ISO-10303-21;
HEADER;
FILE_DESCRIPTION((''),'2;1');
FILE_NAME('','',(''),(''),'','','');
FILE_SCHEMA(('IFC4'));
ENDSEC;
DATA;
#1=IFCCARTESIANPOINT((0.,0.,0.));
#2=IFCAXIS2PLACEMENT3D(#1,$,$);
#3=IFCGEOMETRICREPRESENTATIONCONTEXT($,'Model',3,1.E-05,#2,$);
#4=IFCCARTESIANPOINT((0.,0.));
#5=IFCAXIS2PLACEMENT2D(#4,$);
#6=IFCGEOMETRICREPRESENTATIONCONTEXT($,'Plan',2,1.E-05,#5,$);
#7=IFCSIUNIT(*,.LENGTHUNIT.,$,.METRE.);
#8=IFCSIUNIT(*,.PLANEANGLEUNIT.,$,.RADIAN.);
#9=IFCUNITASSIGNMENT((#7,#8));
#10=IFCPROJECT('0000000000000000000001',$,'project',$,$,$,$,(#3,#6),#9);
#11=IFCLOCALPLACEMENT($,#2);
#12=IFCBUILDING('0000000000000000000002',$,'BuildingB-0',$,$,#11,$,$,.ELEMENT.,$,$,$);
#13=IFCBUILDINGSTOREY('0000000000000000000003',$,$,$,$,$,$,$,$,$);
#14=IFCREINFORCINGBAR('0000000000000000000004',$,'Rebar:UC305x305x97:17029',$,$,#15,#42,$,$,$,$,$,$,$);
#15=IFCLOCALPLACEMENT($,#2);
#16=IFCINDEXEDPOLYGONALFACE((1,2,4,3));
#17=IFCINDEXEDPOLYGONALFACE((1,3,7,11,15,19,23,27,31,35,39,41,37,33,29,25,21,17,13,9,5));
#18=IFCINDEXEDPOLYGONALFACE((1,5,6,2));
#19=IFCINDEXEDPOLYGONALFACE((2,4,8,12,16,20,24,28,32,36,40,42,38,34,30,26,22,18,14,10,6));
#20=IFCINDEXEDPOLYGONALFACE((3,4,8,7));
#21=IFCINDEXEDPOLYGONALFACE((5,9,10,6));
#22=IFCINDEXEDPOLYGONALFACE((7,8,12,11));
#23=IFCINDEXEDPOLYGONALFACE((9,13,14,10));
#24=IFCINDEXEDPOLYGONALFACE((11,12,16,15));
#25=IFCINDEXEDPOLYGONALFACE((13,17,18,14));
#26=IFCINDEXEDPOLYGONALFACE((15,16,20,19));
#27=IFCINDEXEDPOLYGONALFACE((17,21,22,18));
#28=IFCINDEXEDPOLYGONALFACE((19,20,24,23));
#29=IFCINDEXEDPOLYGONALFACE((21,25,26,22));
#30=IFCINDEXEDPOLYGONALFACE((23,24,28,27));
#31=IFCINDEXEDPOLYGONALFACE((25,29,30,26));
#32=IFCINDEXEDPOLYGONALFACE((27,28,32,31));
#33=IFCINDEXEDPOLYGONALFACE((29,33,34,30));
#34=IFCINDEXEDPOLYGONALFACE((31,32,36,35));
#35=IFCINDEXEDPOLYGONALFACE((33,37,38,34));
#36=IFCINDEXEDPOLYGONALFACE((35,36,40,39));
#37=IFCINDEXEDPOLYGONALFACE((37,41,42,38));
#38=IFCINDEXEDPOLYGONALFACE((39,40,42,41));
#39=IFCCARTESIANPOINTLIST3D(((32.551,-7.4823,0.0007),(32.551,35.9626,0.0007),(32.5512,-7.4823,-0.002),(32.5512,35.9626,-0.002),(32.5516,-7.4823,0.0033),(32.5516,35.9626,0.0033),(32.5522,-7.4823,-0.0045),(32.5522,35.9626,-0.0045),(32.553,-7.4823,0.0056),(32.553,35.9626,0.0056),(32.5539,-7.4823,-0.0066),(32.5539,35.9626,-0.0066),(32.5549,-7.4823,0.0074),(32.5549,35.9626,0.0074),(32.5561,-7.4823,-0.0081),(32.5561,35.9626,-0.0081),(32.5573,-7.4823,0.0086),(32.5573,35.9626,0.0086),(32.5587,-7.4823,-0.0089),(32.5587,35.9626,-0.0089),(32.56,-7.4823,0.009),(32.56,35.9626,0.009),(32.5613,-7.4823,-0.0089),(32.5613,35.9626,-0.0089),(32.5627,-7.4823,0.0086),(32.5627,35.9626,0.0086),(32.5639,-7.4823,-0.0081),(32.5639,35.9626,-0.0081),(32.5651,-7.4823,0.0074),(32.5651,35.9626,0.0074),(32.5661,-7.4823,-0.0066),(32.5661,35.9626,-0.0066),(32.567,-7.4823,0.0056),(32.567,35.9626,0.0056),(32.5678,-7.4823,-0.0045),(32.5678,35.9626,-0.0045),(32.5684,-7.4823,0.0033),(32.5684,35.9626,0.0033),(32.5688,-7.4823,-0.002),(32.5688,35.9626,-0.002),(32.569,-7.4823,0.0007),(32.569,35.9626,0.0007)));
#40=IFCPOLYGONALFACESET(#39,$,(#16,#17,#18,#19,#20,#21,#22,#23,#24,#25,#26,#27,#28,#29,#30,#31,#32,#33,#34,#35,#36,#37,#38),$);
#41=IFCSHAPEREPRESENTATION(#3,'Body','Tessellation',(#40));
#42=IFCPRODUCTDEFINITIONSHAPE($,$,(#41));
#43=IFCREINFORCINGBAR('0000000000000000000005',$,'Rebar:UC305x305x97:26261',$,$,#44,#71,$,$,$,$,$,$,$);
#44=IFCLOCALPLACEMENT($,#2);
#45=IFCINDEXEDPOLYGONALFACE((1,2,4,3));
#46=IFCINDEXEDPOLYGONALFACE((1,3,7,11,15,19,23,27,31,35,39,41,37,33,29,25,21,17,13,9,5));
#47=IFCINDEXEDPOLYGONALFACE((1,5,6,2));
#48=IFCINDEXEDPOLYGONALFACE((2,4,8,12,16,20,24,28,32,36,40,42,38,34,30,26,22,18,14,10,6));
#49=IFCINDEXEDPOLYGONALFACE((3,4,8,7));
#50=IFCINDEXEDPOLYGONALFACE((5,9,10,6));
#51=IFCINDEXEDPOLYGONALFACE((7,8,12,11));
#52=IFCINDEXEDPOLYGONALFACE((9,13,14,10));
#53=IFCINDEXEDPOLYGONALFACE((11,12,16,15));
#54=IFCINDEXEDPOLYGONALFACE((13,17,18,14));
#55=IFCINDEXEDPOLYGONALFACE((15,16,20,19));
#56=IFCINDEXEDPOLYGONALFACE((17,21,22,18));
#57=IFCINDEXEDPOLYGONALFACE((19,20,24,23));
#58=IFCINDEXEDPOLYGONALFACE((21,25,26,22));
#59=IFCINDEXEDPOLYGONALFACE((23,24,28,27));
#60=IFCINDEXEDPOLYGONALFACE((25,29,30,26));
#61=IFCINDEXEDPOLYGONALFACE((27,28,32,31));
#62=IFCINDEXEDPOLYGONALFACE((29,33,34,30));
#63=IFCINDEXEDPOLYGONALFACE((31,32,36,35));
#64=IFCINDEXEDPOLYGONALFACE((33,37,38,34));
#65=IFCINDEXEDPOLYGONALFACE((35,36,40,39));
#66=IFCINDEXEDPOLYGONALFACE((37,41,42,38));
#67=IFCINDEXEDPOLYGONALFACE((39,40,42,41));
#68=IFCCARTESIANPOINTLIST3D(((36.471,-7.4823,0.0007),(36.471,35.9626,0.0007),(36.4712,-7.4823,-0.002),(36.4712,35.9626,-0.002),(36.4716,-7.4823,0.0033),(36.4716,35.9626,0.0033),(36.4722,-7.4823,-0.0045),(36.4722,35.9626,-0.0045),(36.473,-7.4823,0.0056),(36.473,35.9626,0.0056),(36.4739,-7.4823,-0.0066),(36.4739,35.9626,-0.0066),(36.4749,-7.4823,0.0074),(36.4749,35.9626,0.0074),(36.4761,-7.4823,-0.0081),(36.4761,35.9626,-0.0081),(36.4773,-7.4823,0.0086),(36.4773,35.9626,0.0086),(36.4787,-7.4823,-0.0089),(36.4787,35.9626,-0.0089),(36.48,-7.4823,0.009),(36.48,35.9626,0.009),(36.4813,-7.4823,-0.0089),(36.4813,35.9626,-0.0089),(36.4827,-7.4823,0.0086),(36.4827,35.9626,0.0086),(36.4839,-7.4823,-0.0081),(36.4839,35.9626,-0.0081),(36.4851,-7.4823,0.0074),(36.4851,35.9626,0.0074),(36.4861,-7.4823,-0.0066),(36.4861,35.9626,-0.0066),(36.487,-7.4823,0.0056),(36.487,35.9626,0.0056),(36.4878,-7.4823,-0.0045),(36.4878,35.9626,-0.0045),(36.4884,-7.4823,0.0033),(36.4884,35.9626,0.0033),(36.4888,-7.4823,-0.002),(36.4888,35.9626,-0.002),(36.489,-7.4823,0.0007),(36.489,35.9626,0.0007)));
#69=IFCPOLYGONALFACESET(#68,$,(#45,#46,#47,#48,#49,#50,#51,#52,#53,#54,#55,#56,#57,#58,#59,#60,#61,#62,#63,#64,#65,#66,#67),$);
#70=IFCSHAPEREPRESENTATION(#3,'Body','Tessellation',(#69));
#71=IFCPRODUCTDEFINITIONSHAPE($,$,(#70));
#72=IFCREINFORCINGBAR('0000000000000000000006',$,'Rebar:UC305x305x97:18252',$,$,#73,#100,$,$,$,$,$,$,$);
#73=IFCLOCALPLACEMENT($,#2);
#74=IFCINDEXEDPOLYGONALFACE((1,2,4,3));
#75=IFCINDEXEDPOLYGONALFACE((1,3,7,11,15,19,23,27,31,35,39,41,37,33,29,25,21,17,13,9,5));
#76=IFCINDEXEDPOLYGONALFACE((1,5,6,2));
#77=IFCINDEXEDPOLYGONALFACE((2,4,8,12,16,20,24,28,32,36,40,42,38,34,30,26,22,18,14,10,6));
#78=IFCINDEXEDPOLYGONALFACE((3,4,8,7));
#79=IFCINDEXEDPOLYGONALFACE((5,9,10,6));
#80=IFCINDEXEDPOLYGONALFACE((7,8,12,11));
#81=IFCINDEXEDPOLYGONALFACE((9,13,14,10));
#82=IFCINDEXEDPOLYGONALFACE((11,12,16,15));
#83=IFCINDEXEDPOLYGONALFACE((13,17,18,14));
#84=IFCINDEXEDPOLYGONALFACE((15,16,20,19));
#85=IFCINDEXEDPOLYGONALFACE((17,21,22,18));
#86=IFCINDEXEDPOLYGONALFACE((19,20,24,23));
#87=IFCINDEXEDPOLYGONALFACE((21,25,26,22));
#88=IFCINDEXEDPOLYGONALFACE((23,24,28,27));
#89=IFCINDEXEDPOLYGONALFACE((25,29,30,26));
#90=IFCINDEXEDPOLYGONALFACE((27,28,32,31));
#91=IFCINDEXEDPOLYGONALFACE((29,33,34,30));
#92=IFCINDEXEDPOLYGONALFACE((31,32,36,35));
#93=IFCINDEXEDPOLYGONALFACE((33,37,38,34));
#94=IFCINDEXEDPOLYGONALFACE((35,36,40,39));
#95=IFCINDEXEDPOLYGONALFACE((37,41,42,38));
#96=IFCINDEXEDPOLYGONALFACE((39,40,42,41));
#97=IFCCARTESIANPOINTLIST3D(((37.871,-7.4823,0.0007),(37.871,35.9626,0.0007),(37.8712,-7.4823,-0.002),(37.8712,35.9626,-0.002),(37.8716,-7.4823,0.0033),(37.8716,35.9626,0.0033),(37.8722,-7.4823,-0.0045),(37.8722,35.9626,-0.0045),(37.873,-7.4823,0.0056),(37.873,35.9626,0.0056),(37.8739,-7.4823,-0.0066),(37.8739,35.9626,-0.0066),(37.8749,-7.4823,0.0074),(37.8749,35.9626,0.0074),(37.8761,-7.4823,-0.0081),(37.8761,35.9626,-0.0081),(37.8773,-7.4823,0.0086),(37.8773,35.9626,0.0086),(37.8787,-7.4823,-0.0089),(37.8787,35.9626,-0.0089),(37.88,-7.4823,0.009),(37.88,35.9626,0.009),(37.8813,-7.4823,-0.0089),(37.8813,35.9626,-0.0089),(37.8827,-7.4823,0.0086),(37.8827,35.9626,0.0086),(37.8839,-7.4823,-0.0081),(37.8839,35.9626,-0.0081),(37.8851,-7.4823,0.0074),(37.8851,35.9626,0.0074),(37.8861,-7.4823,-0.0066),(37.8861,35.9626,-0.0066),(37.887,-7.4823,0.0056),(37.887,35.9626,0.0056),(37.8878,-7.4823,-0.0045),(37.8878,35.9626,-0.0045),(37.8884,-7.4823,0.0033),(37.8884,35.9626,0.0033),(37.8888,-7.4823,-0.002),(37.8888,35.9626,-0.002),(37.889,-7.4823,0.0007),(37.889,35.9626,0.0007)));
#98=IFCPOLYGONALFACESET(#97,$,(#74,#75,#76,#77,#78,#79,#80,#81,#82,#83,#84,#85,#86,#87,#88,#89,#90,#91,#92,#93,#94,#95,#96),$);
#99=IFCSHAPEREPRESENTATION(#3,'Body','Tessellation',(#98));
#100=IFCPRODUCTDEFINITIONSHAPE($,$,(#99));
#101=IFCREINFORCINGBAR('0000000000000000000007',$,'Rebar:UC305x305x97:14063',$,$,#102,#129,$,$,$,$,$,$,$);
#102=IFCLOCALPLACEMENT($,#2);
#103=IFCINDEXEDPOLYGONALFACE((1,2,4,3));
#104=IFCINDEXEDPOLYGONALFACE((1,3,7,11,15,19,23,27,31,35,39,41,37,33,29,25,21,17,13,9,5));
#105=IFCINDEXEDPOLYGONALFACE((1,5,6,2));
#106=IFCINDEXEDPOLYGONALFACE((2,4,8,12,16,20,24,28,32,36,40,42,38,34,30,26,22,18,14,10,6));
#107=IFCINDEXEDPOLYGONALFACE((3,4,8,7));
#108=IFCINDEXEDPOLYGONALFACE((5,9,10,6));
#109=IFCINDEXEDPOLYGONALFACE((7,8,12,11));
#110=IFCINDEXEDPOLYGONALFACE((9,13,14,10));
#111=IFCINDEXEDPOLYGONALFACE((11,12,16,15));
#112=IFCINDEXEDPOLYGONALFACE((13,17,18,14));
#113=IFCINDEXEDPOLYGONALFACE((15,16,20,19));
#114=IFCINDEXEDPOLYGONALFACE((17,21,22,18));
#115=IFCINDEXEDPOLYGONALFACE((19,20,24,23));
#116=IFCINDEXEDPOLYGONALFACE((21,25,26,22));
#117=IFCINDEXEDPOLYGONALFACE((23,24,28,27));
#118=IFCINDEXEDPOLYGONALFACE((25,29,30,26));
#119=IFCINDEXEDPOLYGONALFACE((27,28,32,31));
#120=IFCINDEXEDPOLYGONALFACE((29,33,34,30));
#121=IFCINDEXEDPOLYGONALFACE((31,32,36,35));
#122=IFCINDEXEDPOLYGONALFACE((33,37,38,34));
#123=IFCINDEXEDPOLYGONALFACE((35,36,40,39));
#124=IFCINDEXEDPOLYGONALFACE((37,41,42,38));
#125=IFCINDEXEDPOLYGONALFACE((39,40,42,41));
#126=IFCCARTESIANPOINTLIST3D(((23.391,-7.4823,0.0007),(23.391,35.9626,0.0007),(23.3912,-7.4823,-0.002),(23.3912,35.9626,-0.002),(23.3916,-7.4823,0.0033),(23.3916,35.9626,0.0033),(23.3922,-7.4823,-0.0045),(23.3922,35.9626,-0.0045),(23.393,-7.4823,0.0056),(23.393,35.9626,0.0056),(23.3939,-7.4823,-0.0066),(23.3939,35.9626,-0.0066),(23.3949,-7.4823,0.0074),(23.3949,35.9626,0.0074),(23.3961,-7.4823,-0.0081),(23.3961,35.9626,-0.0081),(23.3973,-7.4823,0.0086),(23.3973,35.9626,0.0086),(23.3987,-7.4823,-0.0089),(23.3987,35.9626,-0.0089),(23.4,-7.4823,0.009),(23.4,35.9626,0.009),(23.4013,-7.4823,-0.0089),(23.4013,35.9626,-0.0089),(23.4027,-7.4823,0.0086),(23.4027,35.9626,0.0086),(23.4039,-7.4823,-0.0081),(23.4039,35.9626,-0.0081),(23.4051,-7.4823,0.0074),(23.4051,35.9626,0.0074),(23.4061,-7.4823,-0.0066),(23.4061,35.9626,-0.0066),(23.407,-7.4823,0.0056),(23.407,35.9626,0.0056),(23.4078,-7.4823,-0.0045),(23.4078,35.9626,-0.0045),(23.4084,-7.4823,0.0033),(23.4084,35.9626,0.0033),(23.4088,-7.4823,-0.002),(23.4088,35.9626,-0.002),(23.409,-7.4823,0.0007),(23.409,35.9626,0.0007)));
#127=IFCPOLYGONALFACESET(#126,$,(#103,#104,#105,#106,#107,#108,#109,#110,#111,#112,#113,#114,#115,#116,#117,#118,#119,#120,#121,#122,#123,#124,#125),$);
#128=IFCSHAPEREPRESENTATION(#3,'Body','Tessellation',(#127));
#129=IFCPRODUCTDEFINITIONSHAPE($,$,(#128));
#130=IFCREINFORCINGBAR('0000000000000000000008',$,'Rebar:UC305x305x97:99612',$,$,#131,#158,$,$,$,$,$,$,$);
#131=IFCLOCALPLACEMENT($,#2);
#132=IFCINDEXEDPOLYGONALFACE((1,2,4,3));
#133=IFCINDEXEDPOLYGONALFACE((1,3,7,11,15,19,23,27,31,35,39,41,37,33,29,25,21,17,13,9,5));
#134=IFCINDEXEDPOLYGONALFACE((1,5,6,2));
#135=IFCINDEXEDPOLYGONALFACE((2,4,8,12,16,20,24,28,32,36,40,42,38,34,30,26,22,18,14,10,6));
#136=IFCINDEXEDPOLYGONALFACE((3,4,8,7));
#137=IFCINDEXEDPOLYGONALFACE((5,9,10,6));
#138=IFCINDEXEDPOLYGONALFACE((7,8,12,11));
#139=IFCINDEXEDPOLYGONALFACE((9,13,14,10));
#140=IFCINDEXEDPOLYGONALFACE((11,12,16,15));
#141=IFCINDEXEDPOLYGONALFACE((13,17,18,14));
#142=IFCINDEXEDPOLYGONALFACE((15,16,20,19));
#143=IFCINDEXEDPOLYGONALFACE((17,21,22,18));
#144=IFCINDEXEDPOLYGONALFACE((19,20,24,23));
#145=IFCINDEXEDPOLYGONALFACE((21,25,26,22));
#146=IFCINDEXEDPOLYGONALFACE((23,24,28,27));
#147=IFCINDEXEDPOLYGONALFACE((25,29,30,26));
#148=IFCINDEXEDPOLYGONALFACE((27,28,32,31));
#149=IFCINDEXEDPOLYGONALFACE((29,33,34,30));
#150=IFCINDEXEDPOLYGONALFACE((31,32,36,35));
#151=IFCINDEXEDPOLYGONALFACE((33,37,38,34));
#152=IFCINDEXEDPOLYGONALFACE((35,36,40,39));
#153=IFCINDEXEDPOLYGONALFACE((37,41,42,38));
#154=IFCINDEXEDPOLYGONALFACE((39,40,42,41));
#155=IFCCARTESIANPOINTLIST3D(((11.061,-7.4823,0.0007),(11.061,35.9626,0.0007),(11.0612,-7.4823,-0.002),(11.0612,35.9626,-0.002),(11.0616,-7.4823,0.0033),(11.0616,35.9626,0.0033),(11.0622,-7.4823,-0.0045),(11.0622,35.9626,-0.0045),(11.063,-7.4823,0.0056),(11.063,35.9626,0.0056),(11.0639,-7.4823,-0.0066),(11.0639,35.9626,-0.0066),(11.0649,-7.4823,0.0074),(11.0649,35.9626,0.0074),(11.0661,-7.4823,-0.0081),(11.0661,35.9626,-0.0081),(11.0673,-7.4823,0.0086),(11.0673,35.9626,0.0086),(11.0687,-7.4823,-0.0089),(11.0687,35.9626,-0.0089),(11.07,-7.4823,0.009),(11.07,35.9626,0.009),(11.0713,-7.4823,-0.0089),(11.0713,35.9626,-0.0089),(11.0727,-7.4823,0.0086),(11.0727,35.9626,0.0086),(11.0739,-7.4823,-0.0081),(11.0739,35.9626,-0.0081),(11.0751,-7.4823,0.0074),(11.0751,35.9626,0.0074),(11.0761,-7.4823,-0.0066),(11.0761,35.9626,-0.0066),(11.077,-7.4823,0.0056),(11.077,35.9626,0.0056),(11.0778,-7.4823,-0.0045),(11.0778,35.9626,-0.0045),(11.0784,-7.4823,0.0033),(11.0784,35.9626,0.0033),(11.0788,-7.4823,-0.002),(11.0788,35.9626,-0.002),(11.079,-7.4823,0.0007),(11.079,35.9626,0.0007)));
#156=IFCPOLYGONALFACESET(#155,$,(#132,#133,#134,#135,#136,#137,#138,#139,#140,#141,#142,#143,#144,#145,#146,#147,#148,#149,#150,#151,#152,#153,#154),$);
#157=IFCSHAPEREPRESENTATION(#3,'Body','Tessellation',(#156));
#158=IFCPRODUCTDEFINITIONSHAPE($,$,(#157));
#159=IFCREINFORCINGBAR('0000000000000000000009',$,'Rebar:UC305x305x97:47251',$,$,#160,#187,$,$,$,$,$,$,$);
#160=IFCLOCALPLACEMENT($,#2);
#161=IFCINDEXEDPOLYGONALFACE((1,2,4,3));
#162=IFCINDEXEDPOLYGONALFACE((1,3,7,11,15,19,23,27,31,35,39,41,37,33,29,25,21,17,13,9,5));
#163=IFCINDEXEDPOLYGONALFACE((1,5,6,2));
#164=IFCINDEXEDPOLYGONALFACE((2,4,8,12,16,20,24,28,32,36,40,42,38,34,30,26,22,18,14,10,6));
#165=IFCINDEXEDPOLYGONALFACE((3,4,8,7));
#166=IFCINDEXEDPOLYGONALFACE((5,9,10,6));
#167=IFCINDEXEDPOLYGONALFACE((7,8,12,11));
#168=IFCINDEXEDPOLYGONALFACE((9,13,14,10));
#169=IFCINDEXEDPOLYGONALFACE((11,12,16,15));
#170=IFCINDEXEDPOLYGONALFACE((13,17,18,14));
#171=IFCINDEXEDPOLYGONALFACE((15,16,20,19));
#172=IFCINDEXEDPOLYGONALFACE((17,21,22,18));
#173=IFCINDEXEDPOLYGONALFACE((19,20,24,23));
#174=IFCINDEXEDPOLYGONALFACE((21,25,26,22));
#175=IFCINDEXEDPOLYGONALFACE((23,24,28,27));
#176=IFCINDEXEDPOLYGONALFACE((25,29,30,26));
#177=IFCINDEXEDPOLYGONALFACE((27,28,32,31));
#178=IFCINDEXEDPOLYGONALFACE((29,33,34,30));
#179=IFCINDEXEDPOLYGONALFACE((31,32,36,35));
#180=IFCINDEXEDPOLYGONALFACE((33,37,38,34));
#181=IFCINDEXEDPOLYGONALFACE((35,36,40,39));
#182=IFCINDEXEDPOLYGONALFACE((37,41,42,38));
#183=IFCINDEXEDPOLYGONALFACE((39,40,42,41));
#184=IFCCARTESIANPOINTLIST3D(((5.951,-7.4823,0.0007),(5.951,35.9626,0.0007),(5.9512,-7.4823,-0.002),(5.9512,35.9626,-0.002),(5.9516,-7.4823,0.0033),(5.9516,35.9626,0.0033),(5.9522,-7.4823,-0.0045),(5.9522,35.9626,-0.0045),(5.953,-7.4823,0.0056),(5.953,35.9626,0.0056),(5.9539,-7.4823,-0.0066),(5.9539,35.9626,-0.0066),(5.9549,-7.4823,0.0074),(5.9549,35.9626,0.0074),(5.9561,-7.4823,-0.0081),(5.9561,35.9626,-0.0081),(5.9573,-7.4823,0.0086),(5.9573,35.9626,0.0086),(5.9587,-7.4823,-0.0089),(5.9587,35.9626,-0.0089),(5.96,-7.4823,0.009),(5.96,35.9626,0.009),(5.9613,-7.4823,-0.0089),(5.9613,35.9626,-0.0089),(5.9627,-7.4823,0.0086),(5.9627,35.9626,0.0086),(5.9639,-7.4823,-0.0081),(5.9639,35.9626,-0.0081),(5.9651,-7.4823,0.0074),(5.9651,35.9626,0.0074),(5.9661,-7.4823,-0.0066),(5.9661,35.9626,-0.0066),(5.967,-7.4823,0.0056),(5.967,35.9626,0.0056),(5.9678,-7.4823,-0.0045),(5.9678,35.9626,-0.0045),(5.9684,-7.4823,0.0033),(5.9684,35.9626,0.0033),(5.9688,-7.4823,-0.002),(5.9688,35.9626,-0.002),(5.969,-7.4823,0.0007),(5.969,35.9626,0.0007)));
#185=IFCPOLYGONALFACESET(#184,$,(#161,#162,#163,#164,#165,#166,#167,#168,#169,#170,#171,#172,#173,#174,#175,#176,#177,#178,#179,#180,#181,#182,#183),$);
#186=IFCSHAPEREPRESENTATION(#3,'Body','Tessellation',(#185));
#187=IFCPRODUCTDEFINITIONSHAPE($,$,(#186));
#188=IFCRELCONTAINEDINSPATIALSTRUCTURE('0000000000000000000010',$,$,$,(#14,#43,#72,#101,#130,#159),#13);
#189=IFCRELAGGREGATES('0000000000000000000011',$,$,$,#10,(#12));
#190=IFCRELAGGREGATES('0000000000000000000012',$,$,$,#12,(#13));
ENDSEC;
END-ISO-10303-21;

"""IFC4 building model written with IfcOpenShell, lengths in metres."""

from ifc_helpers import new_model, entity, si_unit, origin, origin_2d, place, context, project, spatial, element, save


model = new_model("IFC4")

# Units and contexts
model_context = context("Model", 3, precision=1e-05, world=origin())
plan_context = context("Plan", 2, precision=1e-05, world=origin_2d())
ifc_project = project(units=[si_unit("LENGTHUNIT", "METRE"), si_unit("PLANEANGLEUNIT", "RADIAN")], contexts=[model_context, plan_context])

# Building, storey
building_placement = place(None, origin())
building = spatial("IfcBuilding", under=ifc_project, at=building_placement, Name="BuildingB-0", CompositionType="ELEMENT")
storey = spatial("IfcBuildingStorey", under=building)

# Reinforcing bars
element("IfcReinforcingBar", 1, inside=storey, Name="Rebar:UC305x305x97:17029", context=model_context, shape_type="SweptSolid", body=[
    entity("IfcSurfaceCurveSweptAreaSolid", entity("IfcCircleProfileDef", "AREA", None, None, 0.009), None, entity("IfcPolyline", [entity("IfcCartesianPoint", [32.56, 35.9626, 0.0]), entity("IfcCartesianPoint", [32.56, -7.4823, 0.0])]), None, None, entity("IfcPlane", entity("IfcAxis2Placement3D", entity("IfcCartesianPoint", [32.56, 35.9626, 0.0]), entity("IfcDirection", [0.0, 0.0, 1.0]), entity("IfcDirection", [1.0, 0.0, 0.0])))),
])
element("IfcReinforcingBar", 2, inside=storey, Name="Rebar:UC305x305x97:26261", context=model_context, shape_type="SweptSolid", body=[
    entity("IfcSurfaceCurveSweptAreaSolid", entity("IfcCircleProfileDef", "AREA", None, None, 0.009), None, entity("IfcPolyline", [entity("IfcCartesianPoint", [36.48, 35.9626, 0.0]), entity("IfcCartesianPoint", [36.48, -7.4823, 0.0])]), None, None, entity("IfcPlane", entity("IfcAxis2Placement3D", entity("IfcCartesianPoint", [36.48, 35.9626, 0.0]), entity("IfcDirection", [0.0, 0.0, 1.0]), entity("IfcDirection", [1.0, 0.0, 0.0])))),
])
element("IfcReinforcingBar", 3, inside=storey, Name="Rebar:UC305x305x97:18252", context=model_context, shape_type="SweptSolid", body=[
    entity("IfcSurfaceCurveSweptAreaSolid", entity("IfcCircleProfileDef", "AREA", None, None, 0.009), None, entity("IfcPolyline", [entity("IfcCartesianPoint", [37.88, 35.9626, 0.0]), entity("IfcCartesianPoint", [37.88, -7.4823, 0.0])]), None, None, entity("IfcPlane", entity("IfcAxis2Placement3D", entity("IfcCartesianPoint", [37.88, 35.9626, 0.0]), entity("IfcDirection", [0.0, 0.0, 1.0]), entity("IfcDirection", [1.0, 0.0, 0.0])))),
])
element("IfcReinforcingBar", 4, inside=storey, Name="Rebar:UC305x305x97:14063", context=model_context, shape_type="SweptSolid", body=[
    entity("IfcSurfaceCurveSweptAreaSolid", entity("IfcCircleProfileDef", "AREA", None, None, 0.009), None, entity("IfcPolyline", [entity("IfcCartesianPoint", [23.4, 35.9626, 0.0]), entity("IfcCartesianPoint", [23.4, -7.4823, 0.0])]), None, None, entity("IfcPlane", entity("IfcAxis2Placement3D", entity("IfcCartesianPoint", [23.4, 35.9626, 0.0]), entity("IfcDirection", [0.0, 0.0, 1.0]), entity("IfcDirection", [1.0, 0.0, 0.0])))),
])
element("IfcReinforcingBar", 5, inside=storey, Name="Rebar:UC305x305x97:99612", context=model_context, shape_type="SweptSolid", body=[
    entity("IfcSurfaceCurveSweptAreaSolid", entity("IfcCircleProfileDef", "AREA", None, None, 0.009), None, entity("IfcPolyline", [entity("IfcCartesianPoint", [11.07, 35.9626, 0.0]), entity("IfcCartesianPoint", [11.07, -7.4823, 0.0])]), None, None, entity("IfcPlane", entity("IfcAxis2Placement3D", entity("IfcCartesianPoint", [11.07, 35.9626, 0.0]), entity("IfcDirection", [0.0, 0.0, 1.0]), entity("IfcDirection", [1.0, 0.0, 0.0])))),
])
element("IfcReinforcingBar", 6, inside=storey, Name="Rebar:UC305x305x97:47251", context=model_context, shape_type="SweptSolid", body=[
    entity("IfcSurfaceCurveSweptAreaSolid", entity("IfcCircleProfileDef", "AREA", None, None, 0.009), None, entity("IfcPolyline", [entity("IfcCartesianPoint", [5.96, 35.9626, 0.0]), entity("IfcCartesianPoint", [5.96, -7.4823, 0.0])]), None, None, entity("IfcPlane", entity("IfcAxis2Placement3D", entity("IfcCartesianPoint", [5.96, 35.9626, 0.0]), entity("IfcDirection", [0.0, 0.0, 1.0]), entity("IfcDirection", [1.0, 0.0, 0.0])))),
])

save(model, "model.ifc")
